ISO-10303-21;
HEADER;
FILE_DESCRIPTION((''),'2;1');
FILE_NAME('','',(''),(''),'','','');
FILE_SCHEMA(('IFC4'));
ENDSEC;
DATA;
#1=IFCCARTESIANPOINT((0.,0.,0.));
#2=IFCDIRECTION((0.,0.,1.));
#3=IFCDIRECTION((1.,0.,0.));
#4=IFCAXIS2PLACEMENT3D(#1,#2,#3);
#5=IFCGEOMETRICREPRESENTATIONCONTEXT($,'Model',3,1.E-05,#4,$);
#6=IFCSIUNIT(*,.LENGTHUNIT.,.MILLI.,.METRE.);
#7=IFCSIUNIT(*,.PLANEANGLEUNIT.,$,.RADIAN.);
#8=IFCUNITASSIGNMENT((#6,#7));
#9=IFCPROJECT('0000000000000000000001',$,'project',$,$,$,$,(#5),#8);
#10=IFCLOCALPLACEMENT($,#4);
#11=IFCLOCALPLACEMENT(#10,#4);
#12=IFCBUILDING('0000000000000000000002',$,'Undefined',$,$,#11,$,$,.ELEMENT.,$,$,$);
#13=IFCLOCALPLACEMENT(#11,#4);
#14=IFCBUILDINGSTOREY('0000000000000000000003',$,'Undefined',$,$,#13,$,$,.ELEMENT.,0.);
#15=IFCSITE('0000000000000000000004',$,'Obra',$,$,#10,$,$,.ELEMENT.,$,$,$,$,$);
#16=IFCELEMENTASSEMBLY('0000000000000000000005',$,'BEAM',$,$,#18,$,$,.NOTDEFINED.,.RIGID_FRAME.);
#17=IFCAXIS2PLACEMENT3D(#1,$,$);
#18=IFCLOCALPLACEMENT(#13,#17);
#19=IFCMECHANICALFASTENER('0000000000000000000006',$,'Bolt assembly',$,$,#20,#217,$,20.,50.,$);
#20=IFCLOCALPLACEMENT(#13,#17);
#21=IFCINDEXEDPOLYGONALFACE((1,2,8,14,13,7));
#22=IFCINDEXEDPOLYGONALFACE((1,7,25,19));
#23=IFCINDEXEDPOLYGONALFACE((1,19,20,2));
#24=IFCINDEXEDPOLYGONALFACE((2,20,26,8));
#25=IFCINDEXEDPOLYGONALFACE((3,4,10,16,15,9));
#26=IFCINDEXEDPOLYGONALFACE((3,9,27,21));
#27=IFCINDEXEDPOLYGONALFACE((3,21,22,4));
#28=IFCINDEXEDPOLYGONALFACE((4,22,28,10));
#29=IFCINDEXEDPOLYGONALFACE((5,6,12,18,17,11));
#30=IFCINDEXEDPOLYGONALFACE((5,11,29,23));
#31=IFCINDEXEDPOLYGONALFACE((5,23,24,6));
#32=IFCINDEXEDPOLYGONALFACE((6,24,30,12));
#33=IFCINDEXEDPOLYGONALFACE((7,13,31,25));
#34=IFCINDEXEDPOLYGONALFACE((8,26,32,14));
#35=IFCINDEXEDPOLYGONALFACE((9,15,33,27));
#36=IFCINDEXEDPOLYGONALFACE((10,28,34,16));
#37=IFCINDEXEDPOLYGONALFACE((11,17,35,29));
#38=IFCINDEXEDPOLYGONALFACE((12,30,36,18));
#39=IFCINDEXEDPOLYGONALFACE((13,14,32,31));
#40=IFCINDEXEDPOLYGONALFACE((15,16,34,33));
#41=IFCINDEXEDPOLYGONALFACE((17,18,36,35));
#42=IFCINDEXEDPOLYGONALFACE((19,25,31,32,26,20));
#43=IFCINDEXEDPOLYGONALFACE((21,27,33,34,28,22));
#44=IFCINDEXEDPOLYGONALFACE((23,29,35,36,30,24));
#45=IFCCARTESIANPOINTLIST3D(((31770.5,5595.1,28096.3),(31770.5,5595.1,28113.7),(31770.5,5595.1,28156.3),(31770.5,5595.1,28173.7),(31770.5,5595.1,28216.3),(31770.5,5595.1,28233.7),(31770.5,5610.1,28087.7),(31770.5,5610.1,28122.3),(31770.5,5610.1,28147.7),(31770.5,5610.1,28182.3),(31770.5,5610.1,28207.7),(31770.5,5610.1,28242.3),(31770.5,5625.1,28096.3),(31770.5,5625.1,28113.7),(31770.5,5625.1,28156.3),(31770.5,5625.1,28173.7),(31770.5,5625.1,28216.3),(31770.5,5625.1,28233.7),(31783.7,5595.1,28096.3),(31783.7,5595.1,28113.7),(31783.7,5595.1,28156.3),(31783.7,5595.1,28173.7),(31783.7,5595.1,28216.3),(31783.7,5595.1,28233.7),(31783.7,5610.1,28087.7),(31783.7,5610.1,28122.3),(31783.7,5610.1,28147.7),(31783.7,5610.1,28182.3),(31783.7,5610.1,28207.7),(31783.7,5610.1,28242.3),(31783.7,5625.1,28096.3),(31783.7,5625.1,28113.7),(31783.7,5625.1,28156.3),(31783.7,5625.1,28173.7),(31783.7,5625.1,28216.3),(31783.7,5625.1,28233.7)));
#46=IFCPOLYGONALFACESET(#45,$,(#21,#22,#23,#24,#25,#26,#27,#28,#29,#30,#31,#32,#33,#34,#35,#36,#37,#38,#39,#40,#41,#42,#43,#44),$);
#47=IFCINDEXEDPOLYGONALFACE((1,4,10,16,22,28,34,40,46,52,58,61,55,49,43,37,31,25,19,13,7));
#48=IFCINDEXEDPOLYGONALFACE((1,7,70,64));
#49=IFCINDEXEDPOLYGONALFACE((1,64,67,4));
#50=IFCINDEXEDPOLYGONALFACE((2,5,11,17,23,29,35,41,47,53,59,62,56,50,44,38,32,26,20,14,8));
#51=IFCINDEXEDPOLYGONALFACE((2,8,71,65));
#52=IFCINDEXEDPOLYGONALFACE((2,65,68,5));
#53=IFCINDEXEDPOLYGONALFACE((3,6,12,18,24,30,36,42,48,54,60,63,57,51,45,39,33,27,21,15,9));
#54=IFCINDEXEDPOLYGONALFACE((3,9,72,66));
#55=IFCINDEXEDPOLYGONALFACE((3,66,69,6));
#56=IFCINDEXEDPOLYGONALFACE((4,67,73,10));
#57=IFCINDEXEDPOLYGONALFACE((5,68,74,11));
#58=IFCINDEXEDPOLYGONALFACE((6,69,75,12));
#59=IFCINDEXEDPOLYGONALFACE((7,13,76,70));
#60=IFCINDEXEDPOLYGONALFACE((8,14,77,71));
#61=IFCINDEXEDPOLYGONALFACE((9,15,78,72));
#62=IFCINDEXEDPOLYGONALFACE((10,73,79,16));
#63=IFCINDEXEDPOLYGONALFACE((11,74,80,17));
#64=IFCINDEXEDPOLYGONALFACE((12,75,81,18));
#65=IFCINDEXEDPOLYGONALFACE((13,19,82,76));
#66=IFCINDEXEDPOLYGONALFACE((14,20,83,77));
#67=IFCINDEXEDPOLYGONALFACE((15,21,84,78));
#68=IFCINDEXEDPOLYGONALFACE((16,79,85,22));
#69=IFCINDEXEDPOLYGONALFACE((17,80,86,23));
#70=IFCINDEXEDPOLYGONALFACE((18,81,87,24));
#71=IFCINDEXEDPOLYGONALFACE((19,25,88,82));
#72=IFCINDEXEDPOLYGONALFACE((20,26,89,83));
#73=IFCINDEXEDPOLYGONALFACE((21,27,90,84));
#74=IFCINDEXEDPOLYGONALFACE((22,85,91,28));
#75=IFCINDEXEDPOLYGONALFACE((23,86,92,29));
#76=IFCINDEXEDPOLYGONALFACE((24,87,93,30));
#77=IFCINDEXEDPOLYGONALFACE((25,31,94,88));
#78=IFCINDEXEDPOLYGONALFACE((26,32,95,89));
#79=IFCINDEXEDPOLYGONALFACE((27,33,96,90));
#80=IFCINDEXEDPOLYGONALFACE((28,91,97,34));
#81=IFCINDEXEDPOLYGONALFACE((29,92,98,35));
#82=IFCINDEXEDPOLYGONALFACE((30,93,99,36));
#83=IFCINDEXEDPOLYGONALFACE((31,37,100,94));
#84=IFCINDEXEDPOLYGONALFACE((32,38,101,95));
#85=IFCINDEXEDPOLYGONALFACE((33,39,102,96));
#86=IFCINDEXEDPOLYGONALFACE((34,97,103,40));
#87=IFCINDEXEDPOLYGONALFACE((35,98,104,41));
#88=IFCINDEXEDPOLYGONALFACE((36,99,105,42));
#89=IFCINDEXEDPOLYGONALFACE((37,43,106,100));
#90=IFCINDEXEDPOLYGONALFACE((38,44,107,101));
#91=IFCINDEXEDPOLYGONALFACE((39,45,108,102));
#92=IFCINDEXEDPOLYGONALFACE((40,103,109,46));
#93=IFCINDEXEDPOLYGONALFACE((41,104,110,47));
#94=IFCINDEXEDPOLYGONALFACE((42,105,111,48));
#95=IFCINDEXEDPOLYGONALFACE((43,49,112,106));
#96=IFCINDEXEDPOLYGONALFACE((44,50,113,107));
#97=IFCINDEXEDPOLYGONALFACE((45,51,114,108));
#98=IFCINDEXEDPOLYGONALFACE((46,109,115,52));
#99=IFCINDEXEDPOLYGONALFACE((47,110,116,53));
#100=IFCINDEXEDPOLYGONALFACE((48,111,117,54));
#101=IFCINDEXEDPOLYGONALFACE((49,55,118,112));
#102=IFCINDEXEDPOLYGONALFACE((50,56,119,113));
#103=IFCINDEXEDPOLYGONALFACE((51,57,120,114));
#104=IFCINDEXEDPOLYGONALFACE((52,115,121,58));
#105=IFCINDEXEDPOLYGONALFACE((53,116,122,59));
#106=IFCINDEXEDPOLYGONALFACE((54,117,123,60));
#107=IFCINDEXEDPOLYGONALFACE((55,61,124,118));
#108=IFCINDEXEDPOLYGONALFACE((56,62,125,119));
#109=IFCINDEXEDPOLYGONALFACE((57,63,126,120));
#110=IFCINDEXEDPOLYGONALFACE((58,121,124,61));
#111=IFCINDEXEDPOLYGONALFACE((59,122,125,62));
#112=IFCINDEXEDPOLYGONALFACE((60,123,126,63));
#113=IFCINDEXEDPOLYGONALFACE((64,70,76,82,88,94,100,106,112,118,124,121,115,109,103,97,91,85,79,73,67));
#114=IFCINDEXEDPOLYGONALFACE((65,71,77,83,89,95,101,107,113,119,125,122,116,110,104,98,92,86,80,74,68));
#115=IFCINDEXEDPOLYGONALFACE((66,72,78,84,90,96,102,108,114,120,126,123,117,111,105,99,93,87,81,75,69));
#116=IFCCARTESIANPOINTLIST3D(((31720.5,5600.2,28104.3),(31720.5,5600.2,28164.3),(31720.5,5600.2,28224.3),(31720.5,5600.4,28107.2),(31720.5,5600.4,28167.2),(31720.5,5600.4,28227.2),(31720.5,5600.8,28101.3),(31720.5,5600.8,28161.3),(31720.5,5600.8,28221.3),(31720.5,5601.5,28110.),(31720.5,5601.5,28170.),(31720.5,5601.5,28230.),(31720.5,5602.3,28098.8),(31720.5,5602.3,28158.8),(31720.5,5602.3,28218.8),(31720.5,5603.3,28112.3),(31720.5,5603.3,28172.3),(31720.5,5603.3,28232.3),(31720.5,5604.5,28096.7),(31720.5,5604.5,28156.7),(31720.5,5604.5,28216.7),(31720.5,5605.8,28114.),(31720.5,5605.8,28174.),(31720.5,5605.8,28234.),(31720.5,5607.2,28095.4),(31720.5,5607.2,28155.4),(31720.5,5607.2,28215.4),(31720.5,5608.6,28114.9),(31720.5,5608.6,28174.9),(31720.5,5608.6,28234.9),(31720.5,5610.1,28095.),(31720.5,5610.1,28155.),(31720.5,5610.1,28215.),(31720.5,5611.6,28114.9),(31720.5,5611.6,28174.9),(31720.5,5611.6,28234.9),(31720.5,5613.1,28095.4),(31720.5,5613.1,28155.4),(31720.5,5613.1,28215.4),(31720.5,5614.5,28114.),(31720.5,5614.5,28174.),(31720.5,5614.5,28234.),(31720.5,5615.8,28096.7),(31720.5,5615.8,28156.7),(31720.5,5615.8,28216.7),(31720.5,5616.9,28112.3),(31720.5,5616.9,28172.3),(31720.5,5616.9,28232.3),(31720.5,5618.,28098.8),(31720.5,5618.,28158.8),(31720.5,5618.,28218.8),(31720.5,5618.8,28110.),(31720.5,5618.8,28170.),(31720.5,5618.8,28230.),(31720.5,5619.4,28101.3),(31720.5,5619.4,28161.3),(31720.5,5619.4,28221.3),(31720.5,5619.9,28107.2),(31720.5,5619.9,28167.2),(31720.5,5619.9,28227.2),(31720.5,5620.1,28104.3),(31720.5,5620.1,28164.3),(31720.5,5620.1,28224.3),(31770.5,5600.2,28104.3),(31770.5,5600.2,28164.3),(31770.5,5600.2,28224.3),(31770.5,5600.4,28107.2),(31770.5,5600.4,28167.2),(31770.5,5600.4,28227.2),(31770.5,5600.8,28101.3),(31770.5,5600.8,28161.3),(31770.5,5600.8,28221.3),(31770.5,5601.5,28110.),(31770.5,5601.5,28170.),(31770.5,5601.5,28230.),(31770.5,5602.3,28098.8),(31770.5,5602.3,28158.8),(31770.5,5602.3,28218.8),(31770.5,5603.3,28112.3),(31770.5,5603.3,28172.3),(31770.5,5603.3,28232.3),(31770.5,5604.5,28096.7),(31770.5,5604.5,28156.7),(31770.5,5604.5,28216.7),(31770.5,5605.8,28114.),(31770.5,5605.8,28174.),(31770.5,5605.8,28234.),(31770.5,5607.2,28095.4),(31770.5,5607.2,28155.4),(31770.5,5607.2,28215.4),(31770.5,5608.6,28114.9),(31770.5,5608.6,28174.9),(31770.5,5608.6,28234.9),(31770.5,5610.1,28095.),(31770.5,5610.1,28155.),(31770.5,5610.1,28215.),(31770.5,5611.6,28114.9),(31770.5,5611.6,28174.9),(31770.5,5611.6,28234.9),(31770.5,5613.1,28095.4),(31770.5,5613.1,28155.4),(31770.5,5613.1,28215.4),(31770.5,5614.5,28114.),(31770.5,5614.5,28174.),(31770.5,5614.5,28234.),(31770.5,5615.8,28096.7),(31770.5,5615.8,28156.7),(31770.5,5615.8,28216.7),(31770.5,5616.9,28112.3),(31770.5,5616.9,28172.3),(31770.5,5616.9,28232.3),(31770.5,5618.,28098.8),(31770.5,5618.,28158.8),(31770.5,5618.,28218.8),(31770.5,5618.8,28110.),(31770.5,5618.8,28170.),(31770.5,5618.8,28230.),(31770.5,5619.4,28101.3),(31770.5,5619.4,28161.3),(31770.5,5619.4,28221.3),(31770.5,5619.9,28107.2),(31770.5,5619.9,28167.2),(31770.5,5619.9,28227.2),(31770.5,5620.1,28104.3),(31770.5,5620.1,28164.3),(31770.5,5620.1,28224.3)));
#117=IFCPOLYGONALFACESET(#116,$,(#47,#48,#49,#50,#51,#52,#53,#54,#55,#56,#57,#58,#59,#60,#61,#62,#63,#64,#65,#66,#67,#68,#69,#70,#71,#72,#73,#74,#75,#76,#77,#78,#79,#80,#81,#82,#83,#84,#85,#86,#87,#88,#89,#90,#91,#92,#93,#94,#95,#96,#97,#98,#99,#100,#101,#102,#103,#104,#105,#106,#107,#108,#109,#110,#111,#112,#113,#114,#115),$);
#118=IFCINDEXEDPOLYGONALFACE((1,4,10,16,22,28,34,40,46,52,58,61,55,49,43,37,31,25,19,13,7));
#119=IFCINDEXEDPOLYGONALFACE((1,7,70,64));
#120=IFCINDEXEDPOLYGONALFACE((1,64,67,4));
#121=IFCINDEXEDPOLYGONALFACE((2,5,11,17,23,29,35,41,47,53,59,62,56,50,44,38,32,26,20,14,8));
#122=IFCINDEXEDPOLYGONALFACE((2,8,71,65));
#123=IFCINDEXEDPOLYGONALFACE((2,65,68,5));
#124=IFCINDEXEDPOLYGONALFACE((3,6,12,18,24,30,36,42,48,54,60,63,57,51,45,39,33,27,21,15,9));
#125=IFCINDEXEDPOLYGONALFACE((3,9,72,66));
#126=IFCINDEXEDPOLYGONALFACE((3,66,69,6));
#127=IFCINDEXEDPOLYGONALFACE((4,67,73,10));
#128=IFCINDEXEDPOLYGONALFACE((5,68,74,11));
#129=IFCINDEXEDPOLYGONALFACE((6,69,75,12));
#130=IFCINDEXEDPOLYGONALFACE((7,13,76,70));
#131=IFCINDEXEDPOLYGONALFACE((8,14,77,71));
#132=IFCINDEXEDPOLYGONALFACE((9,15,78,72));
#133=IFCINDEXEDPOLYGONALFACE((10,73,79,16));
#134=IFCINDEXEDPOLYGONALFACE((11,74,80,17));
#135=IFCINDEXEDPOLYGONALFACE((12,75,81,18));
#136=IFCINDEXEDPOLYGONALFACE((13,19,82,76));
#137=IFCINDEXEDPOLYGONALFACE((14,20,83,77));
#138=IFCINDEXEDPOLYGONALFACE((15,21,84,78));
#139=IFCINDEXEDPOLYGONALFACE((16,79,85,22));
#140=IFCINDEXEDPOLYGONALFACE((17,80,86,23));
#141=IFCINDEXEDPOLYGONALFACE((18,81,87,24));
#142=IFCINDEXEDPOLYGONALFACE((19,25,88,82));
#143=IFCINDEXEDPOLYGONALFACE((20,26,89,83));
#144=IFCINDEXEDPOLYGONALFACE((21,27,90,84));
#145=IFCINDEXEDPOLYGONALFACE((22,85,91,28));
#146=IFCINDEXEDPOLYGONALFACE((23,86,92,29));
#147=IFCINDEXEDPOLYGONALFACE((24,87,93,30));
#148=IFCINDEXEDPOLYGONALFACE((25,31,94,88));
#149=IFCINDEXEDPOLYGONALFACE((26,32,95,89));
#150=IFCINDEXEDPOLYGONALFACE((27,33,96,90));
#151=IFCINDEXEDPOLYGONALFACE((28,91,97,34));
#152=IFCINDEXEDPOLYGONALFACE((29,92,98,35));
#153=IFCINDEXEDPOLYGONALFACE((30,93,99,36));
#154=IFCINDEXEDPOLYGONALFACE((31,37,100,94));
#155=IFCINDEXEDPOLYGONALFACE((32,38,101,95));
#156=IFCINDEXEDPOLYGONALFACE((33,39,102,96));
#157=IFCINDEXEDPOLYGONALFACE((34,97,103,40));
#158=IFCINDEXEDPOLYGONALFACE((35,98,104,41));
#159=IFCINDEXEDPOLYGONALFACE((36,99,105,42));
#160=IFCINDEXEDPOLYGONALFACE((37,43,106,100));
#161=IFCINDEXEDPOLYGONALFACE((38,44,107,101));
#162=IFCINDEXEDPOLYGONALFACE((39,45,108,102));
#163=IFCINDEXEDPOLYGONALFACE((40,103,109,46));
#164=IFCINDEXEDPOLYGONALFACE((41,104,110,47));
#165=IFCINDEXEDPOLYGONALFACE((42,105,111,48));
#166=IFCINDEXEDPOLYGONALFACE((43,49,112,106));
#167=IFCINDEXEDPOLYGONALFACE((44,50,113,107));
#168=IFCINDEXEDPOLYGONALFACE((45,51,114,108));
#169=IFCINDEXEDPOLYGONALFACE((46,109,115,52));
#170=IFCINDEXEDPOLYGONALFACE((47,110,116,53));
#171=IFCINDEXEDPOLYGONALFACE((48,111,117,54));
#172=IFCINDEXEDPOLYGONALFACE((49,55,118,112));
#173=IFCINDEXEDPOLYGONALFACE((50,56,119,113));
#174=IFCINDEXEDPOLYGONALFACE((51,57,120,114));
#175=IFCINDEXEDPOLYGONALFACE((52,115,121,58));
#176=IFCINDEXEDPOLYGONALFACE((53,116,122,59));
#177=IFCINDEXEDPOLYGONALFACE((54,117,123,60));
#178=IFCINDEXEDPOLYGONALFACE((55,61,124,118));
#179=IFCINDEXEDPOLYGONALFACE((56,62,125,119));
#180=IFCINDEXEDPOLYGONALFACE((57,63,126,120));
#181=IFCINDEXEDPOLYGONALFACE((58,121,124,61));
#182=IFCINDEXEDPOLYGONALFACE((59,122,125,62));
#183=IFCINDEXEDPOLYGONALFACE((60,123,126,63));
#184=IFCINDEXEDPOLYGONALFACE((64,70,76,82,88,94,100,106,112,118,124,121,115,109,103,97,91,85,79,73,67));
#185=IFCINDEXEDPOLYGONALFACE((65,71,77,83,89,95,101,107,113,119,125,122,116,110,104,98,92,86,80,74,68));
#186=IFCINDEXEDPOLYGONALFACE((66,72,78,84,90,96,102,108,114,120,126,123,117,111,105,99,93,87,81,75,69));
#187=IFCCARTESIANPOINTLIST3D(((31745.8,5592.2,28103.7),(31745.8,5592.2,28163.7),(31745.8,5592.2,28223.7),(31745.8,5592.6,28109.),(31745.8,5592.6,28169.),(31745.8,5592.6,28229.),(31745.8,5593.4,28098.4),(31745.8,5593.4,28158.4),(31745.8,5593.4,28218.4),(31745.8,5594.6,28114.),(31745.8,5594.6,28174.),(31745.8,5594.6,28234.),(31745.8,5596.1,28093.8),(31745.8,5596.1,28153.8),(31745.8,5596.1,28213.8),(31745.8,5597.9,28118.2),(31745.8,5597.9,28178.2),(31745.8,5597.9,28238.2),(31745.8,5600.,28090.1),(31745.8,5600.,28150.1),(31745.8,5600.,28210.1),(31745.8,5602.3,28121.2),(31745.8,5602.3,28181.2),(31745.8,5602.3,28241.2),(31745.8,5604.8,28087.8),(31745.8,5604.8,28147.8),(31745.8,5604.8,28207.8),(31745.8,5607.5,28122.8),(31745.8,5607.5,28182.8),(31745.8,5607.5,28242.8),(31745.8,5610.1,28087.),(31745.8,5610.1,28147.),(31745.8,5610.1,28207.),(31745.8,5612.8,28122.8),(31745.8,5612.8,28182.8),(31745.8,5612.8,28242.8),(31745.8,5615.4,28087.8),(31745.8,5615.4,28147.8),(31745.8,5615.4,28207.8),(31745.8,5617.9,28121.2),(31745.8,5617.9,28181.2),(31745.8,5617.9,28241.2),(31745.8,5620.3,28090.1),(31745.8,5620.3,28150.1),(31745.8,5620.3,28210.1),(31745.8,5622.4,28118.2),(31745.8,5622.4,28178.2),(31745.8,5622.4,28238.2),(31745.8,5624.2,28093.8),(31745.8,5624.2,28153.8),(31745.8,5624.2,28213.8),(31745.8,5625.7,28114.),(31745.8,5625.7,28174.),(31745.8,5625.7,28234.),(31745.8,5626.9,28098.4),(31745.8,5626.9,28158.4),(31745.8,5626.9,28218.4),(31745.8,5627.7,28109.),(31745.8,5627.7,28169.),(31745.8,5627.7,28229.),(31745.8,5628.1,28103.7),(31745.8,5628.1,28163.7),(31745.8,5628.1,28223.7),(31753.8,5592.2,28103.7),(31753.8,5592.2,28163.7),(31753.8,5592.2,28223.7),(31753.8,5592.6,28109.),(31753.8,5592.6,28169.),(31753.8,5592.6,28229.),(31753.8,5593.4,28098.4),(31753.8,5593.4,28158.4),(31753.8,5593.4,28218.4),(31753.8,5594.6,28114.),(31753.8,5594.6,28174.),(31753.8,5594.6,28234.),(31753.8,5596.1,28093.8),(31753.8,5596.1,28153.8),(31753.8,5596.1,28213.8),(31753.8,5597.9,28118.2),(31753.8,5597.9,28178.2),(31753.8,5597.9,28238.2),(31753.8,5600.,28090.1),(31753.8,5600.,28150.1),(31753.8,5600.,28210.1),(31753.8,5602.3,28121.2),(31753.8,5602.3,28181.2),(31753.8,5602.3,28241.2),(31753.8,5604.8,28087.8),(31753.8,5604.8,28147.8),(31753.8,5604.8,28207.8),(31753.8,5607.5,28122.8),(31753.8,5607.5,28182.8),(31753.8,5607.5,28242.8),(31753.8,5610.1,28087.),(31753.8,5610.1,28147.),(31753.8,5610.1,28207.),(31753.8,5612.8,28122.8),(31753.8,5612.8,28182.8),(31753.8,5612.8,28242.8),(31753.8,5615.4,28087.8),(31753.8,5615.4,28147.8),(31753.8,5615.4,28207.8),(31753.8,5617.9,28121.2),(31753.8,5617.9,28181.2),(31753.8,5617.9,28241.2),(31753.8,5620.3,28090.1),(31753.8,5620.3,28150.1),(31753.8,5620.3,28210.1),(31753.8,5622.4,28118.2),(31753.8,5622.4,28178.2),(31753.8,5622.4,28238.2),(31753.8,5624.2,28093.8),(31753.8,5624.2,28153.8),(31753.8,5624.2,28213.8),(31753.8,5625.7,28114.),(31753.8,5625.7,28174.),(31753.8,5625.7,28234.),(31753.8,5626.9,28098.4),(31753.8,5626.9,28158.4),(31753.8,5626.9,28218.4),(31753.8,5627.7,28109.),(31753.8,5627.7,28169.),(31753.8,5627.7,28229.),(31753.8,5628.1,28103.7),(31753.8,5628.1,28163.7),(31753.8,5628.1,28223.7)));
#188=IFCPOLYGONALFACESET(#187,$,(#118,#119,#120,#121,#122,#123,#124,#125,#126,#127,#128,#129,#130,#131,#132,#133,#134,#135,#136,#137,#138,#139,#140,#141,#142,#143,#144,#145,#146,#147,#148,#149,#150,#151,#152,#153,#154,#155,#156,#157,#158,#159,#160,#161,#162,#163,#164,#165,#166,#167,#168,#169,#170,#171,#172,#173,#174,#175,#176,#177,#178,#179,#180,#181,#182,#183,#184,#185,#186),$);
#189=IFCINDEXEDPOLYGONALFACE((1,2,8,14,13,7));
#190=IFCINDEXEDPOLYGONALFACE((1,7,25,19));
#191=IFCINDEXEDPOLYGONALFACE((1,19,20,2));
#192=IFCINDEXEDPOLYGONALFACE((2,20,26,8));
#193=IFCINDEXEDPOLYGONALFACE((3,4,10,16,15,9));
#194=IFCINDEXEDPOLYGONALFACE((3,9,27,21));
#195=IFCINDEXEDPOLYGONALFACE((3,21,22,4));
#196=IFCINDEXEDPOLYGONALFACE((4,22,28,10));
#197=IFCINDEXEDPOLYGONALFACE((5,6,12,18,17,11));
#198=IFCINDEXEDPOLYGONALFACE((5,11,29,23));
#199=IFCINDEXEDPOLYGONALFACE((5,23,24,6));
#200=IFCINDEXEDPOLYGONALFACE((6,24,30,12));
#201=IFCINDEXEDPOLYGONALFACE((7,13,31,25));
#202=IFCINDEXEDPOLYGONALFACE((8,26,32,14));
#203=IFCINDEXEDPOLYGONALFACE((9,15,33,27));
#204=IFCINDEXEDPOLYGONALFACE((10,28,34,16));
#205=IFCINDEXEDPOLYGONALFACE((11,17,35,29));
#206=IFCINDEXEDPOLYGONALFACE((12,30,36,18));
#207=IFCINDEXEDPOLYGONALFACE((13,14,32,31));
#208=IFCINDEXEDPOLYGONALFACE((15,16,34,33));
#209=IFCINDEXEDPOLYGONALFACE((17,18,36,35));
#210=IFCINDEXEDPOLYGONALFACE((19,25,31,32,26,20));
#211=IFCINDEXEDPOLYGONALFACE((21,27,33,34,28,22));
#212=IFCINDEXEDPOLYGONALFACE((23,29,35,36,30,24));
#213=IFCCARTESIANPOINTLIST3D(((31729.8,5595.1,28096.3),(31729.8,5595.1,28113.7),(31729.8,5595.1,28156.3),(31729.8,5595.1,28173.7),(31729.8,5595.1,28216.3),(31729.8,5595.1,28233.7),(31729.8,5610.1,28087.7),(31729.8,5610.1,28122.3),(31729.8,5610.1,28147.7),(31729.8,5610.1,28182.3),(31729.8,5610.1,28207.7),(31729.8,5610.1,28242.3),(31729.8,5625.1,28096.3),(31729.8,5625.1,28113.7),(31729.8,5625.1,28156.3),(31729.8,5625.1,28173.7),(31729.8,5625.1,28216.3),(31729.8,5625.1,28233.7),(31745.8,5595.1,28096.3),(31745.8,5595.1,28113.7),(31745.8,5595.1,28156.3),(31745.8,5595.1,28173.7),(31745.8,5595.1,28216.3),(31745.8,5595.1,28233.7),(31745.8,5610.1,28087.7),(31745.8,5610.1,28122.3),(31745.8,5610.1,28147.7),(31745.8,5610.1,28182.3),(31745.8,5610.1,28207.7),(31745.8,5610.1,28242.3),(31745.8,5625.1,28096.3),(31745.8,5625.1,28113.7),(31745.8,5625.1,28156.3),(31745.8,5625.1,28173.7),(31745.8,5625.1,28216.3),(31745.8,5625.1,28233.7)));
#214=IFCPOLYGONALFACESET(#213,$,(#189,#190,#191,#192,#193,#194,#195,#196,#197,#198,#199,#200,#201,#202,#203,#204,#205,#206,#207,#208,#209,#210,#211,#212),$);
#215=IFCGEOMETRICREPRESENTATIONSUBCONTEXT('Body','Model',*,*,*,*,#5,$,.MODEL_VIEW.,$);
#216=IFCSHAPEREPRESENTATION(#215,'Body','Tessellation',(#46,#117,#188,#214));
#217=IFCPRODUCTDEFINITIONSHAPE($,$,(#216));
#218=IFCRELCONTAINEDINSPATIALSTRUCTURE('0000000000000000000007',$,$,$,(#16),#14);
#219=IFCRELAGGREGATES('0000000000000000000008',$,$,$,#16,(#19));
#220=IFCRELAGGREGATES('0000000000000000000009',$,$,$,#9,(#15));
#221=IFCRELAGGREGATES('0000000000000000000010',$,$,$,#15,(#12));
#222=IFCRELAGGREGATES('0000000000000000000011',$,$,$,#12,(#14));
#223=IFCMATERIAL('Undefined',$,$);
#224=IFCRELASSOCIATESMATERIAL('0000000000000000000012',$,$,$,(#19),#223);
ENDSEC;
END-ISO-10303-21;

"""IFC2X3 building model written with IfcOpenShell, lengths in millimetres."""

from ifc_helpers import new_model, si_unit, frame, origin_with_axes, origin_2d_with_axis, place, context, subcontext, project, spatial, polyline, circle, outline, extrude, source, transform, mapped, material, element, aggregate, save


model = new_model("IFC2X3")

# Units and contexts
model_context = context("Model", 3, precision=1e-05, world=origin_with_axes())
body_context = subcontext(model_context, "Body", "Model", "MODEL_VIEW")
ifc_project = project(units=[si_unit("LENGTHUNIT", "METRE", prefix="MILLI"), si_unit("PLANEANGLEUNIT", "RADIAN")], contexts=[model_context])

# Site, building, storey
site_placement = place(None, origin_with_axes())
site = spatial("IfcSite", under=ifc_project, at=site_placement, Name="Obra", CompositionType="ELEMENT")
building_placement = place(site_placement, origin_with_axes())
building = spatial("IfcBuilding", under=site, at=building_placement, Name="Undefined", CompositionType="ELEMENT")
storey_placement = place(building_placement, origin_with_axes())
storey = spatial("IfcBuildingStorey", under=building, at=storey_placement, Name="Undefined", CompositionType="ELEMENT", Elevation=0.0)

# Shared definitions
ifc_material_1 = material(Name="Undefined")

# Element assembly, mechanical fastener
assembly_1_placement = place(storey_placement, origin_with_axes())
assembly_1 = element("IfcElementAssembly", 1, at=assembly_1_placement, inside=storey, Name="BEAM", AssemblyPlace="NOTDEFINED", PredefinedType="RIGID_FRAME")
shared_shape_1 = source(origin_with_axes(), body_context, "Body", "SweptSolid", [
    extrude(outline(polyline([(17.3, 0.0), (8.7, 15.0), (-8.7, 15.0), (-17.3, 0.0), (-8.7, -15.0), (8.7, -15.0), (17.3, 0.0)])), frame((0.0, -26.3, 0.0), z_axis=(0.0, 1.0, 0.0), x_axis=(1.0, 0.0, 0.0)), (0.0, 0.0, 1.0), 13.2),
    extrude(circle(Radius=10.0, at=origin_2d_with_axis()), frame((0.0, -13.1, 0.0), z_axis=(0.0, 1.0, 0.0), x_axis=(1.0, 0.0, 0.0)), (0.0, 0.0, 1.0), 50.0),
    extrude(circle(Radius=18.0, at=origin_2d_with_axis()), frame((0.0, 3.6, 0.0), z_axis=(0.0, 1.0, 0.0), x_axis=(1.0, 0.0, 0.0)), (0.0, 0.0, 1.0), 8.0),
    extrude(outline(polyline([(17.3, 0.0), (8.7, 15.0), (-8.7, 15.0), (-17.3, 0.0), (-8.7, -15.0), (8.7, -15.0), (17.3, 0.0)])), frame((0.0, 11.6, 0.0), z_axis=(0.0, 1.0, 0.0), x_axis=(1.0, 0.0, 0.0)), (0.0, 0.0, 1.0), 16.0),
])
mechanical_fastener_1_placement = place(assembly_1_placement, frame((31757.5, 5560.1, 28265.0), z_axis=(0.0, 1.0, 0.0), x_axis=(0.0, 0.0, -1.0)))
mechanical_fastener_1 = element("IfcMechanicalFastener", 2, at=mechanical_fastener_1_placement, material=ifc_material_1, Name="Bolt assembly", NominalDiameter=20.0, NominalLength=50.0, context=body_context, shape_type="MappedRepresentation", body=[
    mapped(shared_shape_1, transform((40.0, 0.0, 50.0))),
    mapped(shared_shape_1, transform((100.0, 0.0, 50.0))),
    mapped(shared_shape_1, transform((160.0, 0.0, 50.0))),
])
aggregate(assembly_1, [mechanical_fastener_1])

save(model, "model.ifc")
